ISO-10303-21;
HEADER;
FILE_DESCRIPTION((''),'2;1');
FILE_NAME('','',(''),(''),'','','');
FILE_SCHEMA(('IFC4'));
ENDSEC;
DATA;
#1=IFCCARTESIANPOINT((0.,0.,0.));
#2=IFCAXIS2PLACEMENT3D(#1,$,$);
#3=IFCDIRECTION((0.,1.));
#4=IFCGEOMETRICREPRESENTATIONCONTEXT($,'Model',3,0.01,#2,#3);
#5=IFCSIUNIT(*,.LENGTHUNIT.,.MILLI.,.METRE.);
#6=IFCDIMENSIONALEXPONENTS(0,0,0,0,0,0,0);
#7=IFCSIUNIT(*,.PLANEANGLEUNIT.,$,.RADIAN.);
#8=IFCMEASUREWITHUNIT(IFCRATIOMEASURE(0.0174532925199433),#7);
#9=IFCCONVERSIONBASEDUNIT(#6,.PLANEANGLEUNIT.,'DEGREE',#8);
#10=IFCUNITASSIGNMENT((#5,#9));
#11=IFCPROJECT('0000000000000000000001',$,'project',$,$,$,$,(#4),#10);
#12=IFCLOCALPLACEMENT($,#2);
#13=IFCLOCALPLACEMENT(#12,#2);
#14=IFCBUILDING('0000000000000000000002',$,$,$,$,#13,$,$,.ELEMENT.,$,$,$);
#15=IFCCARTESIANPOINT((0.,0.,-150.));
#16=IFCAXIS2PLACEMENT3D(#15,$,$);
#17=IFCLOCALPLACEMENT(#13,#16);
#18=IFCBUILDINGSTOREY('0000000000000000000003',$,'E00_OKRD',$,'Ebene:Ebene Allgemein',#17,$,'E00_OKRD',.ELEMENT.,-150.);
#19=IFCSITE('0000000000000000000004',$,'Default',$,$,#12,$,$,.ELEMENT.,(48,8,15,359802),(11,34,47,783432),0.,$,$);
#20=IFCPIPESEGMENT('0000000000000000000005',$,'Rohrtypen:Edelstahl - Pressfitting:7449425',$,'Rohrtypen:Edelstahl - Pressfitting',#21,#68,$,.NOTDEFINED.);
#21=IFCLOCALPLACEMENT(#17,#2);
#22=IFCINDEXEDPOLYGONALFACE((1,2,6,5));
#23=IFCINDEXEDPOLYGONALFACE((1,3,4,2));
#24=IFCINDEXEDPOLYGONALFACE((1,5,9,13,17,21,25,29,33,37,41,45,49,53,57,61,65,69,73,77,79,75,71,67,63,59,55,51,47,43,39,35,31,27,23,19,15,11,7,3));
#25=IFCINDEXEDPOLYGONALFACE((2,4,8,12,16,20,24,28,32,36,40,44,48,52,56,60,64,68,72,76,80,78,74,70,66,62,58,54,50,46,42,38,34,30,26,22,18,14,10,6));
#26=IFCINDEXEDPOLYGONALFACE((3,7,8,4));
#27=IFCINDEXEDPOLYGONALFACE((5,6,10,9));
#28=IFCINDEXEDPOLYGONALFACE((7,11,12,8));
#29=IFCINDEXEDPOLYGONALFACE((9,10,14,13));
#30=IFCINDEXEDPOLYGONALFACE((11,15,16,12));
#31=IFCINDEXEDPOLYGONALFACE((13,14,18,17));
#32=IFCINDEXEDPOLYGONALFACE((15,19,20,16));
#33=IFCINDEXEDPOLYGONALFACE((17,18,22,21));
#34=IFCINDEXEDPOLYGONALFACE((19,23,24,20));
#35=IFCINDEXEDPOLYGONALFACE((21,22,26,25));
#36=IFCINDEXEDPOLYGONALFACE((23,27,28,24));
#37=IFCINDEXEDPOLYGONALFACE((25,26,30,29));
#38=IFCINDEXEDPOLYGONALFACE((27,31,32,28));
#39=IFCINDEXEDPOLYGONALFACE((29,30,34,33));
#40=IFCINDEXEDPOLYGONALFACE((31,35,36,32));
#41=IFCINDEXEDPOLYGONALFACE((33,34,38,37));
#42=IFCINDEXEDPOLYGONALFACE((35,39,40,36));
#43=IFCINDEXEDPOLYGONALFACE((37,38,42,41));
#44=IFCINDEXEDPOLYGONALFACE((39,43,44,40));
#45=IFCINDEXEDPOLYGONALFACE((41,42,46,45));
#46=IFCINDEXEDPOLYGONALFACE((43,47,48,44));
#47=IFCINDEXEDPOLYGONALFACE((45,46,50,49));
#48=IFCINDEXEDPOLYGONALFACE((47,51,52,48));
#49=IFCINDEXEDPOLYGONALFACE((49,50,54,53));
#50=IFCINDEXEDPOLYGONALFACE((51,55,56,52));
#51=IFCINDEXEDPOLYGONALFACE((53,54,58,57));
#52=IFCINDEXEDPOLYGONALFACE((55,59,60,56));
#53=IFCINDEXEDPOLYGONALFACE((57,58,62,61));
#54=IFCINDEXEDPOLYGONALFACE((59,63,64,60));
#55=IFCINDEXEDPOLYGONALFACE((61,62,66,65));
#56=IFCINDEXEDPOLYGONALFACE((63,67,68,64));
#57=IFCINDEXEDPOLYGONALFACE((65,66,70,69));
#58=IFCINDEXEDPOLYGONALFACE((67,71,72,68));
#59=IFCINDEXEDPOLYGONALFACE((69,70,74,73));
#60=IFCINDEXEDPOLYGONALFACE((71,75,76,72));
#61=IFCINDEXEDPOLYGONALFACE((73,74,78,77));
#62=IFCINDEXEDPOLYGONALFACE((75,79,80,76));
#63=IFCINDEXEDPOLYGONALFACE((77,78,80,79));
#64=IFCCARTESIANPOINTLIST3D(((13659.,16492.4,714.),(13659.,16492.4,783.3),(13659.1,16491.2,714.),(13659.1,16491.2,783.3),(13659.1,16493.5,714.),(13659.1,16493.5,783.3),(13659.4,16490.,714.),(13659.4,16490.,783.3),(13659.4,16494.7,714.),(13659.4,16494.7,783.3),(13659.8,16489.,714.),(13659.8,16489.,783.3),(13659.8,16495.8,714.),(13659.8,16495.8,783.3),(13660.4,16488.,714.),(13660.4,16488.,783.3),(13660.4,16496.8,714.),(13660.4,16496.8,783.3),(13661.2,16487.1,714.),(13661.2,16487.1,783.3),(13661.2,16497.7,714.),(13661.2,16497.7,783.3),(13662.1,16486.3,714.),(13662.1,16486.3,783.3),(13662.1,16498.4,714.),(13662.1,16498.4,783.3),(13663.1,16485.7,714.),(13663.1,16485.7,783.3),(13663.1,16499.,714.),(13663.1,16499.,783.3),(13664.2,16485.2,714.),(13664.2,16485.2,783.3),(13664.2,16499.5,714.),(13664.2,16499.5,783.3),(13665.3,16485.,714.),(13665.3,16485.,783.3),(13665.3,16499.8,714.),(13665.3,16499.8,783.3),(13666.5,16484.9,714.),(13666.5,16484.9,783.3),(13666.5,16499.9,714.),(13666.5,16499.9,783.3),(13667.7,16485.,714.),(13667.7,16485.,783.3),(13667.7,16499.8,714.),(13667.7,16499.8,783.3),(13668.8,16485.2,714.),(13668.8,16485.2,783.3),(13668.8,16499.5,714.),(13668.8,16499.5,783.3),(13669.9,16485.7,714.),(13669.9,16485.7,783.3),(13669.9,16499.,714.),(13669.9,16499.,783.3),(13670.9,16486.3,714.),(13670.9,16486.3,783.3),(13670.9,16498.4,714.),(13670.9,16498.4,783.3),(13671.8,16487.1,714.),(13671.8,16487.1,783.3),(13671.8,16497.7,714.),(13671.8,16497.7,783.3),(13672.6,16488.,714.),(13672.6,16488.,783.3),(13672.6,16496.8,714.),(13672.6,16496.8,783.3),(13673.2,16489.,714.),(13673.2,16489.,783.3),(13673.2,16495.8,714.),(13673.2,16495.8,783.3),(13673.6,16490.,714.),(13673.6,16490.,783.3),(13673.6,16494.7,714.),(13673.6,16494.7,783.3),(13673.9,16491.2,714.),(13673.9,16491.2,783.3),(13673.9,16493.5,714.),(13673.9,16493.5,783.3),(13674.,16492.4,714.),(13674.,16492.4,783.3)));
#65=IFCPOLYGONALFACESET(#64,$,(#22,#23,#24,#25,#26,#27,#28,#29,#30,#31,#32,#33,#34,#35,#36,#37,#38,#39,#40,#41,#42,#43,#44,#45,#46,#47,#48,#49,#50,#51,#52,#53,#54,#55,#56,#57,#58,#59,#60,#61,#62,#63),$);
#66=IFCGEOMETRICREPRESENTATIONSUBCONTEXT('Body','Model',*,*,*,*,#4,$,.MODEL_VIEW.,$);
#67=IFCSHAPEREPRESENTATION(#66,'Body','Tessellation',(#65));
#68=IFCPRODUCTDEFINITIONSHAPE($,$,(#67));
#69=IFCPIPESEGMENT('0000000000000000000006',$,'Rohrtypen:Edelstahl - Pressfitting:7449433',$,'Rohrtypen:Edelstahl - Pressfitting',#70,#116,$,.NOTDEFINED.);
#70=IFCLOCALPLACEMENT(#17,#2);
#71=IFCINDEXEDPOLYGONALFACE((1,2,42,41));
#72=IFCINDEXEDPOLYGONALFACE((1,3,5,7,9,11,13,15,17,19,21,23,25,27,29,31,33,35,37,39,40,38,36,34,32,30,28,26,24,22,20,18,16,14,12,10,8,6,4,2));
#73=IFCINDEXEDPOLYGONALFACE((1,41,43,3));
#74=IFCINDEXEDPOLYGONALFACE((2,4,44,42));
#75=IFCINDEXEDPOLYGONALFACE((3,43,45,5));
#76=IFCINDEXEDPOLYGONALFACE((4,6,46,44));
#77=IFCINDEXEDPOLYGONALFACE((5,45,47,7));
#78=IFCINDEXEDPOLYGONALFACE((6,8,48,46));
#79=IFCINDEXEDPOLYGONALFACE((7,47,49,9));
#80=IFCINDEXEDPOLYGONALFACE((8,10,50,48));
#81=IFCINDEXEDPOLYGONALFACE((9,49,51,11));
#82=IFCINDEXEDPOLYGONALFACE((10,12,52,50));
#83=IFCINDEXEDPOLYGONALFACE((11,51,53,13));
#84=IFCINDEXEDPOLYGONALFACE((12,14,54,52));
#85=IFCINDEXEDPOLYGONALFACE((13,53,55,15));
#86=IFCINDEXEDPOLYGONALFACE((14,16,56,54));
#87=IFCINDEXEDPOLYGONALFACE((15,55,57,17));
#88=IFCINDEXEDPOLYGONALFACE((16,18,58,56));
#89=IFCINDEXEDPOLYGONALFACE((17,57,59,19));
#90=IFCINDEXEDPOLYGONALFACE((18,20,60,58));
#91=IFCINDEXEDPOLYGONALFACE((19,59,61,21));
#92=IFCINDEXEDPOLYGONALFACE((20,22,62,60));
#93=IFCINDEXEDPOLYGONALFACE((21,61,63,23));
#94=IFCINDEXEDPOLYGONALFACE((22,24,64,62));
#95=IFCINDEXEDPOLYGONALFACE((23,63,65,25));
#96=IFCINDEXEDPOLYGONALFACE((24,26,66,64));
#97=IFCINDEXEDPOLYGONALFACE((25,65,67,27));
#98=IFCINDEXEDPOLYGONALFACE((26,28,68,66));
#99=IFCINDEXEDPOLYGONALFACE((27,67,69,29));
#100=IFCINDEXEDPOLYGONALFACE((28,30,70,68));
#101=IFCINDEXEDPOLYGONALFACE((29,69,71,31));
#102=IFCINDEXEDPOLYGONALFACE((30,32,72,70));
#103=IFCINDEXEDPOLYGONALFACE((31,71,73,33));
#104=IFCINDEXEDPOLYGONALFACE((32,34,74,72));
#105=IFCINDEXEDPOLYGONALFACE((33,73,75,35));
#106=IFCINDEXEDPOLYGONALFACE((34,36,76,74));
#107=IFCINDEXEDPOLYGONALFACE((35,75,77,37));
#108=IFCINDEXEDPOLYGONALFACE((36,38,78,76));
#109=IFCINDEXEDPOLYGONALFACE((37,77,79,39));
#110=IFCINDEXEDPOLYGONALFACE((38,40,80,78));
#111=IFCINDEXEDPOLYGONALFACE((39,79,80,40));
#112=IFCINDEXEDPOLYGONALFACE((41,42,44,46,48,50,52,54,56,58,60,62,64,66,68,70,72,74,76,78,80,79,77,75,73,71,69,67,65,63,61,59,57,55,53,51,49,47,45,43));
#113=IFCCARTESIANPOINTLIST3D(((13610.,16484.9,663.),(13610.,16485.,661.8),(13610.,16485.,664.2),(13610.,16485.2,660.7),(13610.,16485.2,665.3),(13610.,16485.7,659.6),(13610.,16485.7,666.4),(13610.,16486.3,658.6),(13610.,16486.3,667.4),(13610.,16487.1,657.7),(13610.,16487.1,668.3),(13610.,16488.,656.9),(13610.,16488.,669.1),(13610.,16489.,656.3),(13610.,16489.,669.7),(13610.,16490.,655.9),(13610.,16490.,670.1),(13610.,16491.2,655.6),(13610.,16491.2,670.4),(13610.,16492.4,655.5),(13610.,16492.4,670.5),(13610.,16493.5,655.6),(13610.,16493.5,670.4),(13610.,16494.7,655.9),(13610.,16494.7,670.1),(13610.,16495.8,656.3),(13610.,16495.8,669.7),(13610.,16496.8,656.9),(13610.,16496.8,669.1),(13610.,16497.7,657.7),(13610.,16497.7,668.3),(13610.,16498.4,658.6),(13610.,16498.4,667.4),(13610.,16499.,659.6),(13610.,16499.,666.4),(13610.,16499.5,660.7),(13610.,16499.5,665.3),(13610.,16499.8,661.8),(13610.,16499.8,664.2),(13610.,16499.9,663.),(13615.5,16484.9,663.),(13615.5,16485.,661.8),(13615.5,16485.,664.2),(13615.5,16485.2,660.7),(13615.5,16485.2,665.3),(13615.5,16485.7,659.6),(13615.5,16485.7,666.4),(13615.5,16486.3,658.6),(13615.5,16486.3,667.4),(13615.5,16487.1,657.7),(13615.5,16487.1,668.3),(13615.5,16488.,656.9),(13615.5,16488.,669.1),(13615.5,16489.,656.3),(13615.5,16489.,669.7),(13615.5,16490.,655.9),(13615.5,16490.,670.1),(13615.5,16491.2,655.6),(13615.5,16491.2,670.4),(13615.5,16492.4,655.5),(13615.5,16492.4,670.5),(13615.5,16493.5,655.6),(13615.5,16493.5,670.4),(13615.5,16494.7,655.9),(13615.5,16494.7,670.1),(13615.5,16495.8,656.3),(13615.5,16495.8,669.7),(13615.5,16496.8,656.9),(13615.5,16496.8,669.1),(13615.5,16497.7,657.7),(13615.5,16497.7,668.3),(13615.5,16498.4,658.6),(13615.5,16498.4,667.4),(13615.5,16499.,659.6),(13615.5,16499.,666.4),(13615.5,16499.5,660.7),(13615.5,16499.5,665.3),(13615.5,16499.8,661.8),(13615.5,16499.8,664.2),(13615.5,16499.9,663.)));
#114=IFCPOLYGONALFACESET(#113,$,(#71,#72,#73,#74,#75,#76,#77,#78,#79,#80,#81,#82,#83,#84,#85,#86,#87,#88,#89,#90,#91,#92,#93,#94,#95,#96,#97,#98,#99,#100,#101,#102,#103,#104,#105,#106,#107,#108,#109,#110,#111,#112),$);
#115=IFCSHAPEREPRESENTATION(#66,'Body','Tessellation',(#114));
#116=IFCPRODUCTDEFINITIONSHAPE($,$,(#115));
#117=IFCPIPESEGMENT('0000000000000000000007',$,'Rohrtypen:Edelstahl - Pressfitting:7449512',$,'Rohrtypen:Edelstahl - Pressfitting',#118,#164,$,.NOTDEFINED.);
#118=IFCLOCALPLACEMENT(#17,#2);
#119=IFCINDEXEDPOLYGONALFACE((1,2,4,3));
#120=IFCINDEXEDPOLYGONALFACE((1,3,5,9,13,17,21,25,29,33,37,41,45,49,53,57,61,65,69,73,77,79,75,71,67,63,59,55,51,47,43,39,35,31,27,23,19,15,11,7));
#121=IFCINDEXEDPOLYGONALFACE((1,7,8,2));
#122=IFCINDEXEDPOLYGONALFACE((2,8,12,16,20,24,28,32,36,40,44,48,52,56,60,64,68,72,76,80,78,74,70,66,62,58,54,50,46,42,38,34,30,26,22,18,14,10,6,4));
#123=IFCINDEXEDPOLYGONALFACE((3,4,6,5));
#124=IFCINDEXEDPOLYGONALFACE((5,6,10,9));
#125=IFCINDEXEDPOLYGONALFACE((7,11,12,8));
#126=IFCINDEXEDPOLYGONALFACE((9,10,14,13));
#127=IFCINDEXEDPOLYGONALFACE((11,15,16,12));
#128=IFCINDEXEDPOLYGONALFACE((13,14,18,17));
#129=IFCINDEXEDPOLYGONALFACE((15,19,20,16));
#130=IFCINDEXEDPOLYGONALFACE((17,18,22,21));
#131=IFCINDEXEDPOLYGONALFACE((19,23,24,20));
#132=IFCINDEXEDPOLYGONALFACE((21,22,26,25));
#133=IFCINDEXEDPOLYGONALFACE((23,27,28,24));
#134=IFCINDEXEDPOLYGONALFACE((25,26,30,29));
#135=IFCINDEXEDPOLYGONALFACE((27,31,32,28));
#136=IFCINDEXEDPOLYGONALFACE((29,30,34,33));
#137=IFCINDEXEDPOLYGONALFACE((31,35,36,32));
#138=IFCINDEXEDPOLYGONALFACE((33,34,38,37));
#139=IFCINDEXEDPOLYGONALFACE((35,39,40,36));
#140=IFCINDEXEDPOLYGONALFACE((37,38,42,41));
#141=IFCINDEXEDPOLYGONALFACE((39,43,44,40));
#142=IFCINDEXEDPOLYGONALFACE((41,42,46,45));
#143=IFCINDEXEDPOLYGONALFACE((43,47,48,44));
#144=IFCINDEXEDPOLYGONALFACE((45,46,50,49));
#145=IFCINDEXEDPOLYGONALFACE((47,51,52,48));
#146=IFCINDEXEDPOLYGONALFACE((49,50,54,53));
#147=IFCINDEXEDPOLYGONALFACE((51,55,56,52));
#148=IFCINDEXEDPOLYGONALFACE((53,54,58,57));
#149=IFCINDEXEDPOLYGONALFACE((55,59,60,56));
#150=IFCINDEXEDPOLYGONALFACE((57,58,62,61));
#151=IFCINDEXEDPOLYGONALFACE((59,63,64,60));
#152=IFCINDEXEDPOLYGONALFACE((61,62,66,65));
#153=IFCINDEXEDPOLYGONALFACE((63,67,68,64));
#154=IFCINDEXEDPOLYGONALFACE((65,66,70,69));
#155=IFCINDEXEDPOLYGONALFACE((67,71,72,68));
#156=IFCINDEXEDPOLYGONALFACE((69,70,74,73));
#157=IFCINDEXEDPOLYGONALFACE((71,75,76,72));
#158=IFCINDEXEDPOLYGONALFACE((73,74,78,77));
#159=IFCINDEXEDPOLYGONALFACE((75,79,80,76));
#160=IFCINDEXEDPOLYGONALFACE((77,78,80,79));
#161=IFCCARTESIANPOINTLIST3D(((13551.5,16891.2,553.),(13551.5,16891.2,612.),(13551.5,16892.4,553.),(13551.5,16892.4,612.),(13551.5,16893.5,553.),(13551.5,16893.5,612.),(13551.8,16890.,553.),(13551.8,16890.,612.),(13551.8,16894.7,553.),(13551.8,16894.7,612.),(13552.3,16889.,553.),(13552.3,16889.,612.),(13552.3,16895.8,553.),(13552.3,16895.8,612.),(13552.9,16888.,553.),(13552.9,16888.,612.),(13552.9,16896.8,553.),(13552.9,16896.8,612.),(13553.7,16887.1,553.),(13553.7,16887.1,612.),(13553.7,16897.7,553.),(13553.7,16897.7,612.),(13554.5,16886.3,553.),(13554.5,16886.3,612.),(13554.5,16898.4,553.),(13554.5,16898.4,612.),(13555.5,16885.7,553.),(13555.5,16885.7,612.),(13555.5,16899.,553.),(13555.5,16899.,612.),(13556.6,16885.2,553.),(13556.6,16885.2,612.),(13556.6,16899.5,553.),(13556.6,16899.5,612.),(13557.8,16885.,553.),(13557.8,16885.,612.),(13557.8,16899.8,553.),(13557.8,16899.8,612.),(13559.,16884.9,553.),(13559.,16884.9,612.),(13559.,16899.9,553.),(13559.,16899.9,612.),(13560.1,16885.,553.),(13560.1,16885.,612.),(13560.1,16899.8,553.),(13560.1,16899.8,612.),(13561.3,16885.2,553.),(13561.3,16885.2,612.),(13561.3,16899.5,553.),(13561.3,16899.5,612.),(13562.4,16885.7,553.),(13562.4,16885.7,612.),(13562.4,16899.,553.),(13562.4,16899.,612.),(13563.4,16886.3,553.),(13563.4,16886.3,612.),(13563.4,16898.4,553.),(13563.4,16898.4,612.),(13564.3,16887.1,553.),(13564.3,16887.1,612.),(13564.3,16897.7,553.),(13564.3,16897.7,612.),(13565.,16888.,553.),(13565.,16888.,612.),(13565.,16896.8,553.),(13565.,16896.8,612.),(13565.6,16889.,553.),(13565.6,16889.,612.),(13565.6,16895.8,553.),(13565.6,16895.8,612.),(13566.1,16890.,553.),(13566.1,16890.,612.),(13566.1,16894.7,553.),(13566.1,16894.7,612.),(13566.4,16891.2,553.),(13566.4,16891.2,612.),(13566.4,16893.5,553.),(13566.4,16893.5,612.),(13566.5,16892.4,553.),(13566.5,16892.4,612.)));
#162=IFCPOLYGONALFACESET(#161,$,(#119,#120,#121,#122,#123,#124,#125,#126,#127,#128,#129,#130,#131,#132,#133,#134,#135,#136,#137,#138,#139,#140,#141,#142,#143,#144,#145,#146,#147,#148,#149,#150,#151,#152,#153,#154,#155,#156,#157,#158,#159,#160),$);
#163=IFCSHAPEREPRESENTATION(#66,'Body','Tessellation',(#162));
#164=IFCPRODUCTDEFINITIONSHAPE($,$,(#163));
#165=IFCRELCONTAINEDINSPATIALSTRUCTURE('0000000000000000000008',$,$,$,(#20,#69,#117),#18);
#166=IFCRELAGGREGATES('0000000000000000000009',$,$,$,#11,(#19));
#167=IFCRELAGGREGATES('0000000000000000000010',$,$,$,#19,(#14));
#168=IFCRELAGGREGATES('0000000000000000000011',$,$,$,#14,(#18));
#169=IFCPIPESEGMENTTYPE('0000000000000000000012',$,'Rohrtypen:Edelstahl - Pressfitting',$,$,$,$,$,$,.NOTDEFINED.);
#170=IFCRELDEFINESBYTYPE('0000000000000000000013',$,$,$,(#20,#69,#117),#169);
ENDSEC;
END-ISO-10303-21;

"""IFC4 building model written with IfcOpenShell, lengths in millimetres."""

from ifc_helpers import new_model, entity, si_unit, converted_unit, direction, frame, origin, place, context, subcontext, project, spatial, indexed_curve, outline, extrude, type_object, element, save


model = new_model("IFC4")

# Units and contexts
model_context = context("Model", 3, precision=0.01, world=origin(), true_north=direction((0.0, 1.0)))
body_context = subcontext(model_context, "Body", "Model", "MODEL_VIEW")
ifc_project = project(units=[si_unit("LENGTHUNIT", "METRE", prefix="MILLI"), converted_unit("PLANEANGLEUNIT", "DEGREE", entity("IfcRatioMeasure", 0.0174532925199433), si_unit("PLANEANGLEUNIT", "RADIAN"), dimensions=[0, 0, 0, 0, 0, 0, 0])], contexts=[model_context])

# Site, building, storey
site_placement = place(None, origin())
site = spatial("IfcSite", under=ifc_project, at=site_placement, Name="Default", CompositionType="ELEMENT", RefLatitude=(48, 8, 15, 359802), RefLongitude=(11, 34, 47, 783432), RefElevation=0.0)
building_placement = place(site_placement, origin())
building = spatial("IfcBuilding", under=site, at=building_placement, CompositionType="ELEMENT")
storey_placement = place(building_placement, frame((0.0, 0.0, -150.0)))
storey = spatial("IfcBuildingStorey", under=building, at=storey_placement, Name="E00_OKRD", ObjectType="Ebene:Ebene Allgemein", LongName="E00_OKRD", CompositionType="ELEMENT", Elevation=-150.0)

# Pipe segments
pipe_segment_type_1 = type_object("IfcPipeSegmentType", Name="Rohrtypen:Edelstahl - Pressfitting", PredefinedType="NOTDEFINED")
pipe_segment_1_placement = place(storey_placement, origin())
element("IfcPipeSegment", 1, at=pipe_segment_1_placement, inside=storey, type_object=pipe_segment_type_1, Name="Rohrtypen:Edelstahl - Pressfitting:7449425", ObjectType="Rohrtypen:Edelstahl - Pressfitting", PredefinedType="NOTDEFINED", context=body_context, shape_type="SweptSolid", body=[
    extrude(outline(indexed_curve([(7.5, 0.0), (7.4, 1.2), (7.1, 2.3), (6.7, 3.4), (6.1, 4.4), (5.3, 5.3), (4.4, 6.1), (3.4, 6.7), (2.3, 7.1), (1.2, 7.4), (0.0, 7.5), (-1.2, 7.4), (-2.3, 7.1), (-3.4, 6.7), (-4.4, 6.1), (-5.3, 5.3), (-6.1, 4.4), (-6.7, 3.4), (-7.1, 2.3), (-7.4, 1.2), (-7.5, 0.0), (-7.4, -1.2), (-7.1, -2.3), (-6.7, -3.4), (-6.1, -4.4), (-5.3, -5.3), (-4.4, -6.1), (-3.4, -6.7), (-2.3, -7.1), (-1.2, -7.4), (0.0, -7.5), (1.2, -7.4), (2.3, -7.1), (3.4, -6.7), (4.4, -6.1), (5.3, -5.3), (6.1, -4.4), (6.7, -3.4), (7.1, -2.3), (7.4, -1.2), (7.5, 0.0)], self_intersect=False)), frame((13666.5, 16492.4, 714.0)), (0.0, 0.0, 1.0), 69.3),
])
pipe_segment_2_placement = place(storey_placement, origin())
element("IfcPipeSegment", 2, at=pipe_segment_2_placement, inside=storey, type_object=pipe_segment_type_1, Name="Rohrtypen:Edelstahl - Pressfitting:7449433", ObjectType="Rohrtypen:Edelstahl - Pressfitting", PredefinedType="NOTDEFINED", context=body_context, shape_type="SweptSolid", body=[
    extrude(outline(indexed_curve([(7.5, 0.0), (7.4, 1.2), (7.1, 2.3), (6.7, 3.4), (6.1, 4.4), (5.3, 5.3), (4.4, 6.1), (3.4, 6.7), (2.3, 7.1), (1.2, 7.4), (0.0, 7.5), (-1.2, 7.4), (-2.3, 7.1), (-3.4, 6.7), (-4.4, 6.1), (-5.3, 5.3), (-6.1, 4.4), (-6.7, 3.4), (-7.1, 2.3), (-7.4, 1.2), (-7.5, 0.0), (-7.4, -1.2), (-7.1, -2.3), (-6.7, -3.4), (-6.1, -4.4), (-5.3, -5.3), (-4.4, -6.1), (-3.4, -6.7), (-2.3, -7.1), (-1.2, -7.4), (0.0, -7.5), (1.2, -7.4), (2.3, -7.1), (3.4, -6.7), (4.4, -6.1), (5.3, -5.3), (6.1, -4.4), (6.7, -3.4), (7.1, -2.3), (7.4, -1.2), (7.5, 0.0)], self_intersect=False)), frame((13610.0, 16492.4, 663.0), z_axis=(1.0, 0.0, 0.0), x_axis=(0.0, -1.0, 0.0)), (0.0, 0.0, 1.0), 5.6),
])
pipe_segment_3_placement = place(storey_placement, origin())
element("IfcPipeSegment", 3, at=pipe_segment_3_placement, inside=storey, type_object=pipe_segment_type_1, Name="Rohrtypen:Edelstahl - Pressfitting:7449512", ObjectType="Rohrtypen:Edelstahl - Pressfitting", PredefinedType="NOTDEFINED", context=body_context, shape_type="SweptSolid", body=[
    extrude(outline(indexed_curve([(7.5, 0.0), (7.4, 1.2), (7.1, 2.3), (6.7, 3.4), (6.1, 4.4), (5.3, 5.3), (4.4, 6.1), (3.4, 6.7), (2.3, 7.1), (1.2, 7.4), (0.0, 7.5), (-1.2, 7.4), (-2.3, 7.1), (-3.4, 6.7), (-4.4, 6.1), (-5.3, 5.3), (-6.1, 4.4), (-6.7, 3.4), (-7.1, 2.3), (-7.4, 1.2), (-7.5, 0.0), (-7.4, -1.2), (-7.1, -2.3), (-6.7, -3.4), (-6.1, -4.4), (-5.3, -5.3), (-4.4, -6.1), (-3.4, -6.7), (-2.3, -7.1), (-1.2, -7.4), (0.0, -7.5), (1.2, -7.4), (2.3, -7.1), (3.4, -6.7), (4.4, -6.1), (5.3, -5.3), (6.1, -4.4), (6.7, -3.4), (7.1, -2.3), (7.4, -1.2), (7.5, 0.0)], self_intersect=False)), frame((13559.0, 16892.4, 553.0)), (0.0, 0.0, 1.0), 59.0),
])

save(model, "model.ifc")
